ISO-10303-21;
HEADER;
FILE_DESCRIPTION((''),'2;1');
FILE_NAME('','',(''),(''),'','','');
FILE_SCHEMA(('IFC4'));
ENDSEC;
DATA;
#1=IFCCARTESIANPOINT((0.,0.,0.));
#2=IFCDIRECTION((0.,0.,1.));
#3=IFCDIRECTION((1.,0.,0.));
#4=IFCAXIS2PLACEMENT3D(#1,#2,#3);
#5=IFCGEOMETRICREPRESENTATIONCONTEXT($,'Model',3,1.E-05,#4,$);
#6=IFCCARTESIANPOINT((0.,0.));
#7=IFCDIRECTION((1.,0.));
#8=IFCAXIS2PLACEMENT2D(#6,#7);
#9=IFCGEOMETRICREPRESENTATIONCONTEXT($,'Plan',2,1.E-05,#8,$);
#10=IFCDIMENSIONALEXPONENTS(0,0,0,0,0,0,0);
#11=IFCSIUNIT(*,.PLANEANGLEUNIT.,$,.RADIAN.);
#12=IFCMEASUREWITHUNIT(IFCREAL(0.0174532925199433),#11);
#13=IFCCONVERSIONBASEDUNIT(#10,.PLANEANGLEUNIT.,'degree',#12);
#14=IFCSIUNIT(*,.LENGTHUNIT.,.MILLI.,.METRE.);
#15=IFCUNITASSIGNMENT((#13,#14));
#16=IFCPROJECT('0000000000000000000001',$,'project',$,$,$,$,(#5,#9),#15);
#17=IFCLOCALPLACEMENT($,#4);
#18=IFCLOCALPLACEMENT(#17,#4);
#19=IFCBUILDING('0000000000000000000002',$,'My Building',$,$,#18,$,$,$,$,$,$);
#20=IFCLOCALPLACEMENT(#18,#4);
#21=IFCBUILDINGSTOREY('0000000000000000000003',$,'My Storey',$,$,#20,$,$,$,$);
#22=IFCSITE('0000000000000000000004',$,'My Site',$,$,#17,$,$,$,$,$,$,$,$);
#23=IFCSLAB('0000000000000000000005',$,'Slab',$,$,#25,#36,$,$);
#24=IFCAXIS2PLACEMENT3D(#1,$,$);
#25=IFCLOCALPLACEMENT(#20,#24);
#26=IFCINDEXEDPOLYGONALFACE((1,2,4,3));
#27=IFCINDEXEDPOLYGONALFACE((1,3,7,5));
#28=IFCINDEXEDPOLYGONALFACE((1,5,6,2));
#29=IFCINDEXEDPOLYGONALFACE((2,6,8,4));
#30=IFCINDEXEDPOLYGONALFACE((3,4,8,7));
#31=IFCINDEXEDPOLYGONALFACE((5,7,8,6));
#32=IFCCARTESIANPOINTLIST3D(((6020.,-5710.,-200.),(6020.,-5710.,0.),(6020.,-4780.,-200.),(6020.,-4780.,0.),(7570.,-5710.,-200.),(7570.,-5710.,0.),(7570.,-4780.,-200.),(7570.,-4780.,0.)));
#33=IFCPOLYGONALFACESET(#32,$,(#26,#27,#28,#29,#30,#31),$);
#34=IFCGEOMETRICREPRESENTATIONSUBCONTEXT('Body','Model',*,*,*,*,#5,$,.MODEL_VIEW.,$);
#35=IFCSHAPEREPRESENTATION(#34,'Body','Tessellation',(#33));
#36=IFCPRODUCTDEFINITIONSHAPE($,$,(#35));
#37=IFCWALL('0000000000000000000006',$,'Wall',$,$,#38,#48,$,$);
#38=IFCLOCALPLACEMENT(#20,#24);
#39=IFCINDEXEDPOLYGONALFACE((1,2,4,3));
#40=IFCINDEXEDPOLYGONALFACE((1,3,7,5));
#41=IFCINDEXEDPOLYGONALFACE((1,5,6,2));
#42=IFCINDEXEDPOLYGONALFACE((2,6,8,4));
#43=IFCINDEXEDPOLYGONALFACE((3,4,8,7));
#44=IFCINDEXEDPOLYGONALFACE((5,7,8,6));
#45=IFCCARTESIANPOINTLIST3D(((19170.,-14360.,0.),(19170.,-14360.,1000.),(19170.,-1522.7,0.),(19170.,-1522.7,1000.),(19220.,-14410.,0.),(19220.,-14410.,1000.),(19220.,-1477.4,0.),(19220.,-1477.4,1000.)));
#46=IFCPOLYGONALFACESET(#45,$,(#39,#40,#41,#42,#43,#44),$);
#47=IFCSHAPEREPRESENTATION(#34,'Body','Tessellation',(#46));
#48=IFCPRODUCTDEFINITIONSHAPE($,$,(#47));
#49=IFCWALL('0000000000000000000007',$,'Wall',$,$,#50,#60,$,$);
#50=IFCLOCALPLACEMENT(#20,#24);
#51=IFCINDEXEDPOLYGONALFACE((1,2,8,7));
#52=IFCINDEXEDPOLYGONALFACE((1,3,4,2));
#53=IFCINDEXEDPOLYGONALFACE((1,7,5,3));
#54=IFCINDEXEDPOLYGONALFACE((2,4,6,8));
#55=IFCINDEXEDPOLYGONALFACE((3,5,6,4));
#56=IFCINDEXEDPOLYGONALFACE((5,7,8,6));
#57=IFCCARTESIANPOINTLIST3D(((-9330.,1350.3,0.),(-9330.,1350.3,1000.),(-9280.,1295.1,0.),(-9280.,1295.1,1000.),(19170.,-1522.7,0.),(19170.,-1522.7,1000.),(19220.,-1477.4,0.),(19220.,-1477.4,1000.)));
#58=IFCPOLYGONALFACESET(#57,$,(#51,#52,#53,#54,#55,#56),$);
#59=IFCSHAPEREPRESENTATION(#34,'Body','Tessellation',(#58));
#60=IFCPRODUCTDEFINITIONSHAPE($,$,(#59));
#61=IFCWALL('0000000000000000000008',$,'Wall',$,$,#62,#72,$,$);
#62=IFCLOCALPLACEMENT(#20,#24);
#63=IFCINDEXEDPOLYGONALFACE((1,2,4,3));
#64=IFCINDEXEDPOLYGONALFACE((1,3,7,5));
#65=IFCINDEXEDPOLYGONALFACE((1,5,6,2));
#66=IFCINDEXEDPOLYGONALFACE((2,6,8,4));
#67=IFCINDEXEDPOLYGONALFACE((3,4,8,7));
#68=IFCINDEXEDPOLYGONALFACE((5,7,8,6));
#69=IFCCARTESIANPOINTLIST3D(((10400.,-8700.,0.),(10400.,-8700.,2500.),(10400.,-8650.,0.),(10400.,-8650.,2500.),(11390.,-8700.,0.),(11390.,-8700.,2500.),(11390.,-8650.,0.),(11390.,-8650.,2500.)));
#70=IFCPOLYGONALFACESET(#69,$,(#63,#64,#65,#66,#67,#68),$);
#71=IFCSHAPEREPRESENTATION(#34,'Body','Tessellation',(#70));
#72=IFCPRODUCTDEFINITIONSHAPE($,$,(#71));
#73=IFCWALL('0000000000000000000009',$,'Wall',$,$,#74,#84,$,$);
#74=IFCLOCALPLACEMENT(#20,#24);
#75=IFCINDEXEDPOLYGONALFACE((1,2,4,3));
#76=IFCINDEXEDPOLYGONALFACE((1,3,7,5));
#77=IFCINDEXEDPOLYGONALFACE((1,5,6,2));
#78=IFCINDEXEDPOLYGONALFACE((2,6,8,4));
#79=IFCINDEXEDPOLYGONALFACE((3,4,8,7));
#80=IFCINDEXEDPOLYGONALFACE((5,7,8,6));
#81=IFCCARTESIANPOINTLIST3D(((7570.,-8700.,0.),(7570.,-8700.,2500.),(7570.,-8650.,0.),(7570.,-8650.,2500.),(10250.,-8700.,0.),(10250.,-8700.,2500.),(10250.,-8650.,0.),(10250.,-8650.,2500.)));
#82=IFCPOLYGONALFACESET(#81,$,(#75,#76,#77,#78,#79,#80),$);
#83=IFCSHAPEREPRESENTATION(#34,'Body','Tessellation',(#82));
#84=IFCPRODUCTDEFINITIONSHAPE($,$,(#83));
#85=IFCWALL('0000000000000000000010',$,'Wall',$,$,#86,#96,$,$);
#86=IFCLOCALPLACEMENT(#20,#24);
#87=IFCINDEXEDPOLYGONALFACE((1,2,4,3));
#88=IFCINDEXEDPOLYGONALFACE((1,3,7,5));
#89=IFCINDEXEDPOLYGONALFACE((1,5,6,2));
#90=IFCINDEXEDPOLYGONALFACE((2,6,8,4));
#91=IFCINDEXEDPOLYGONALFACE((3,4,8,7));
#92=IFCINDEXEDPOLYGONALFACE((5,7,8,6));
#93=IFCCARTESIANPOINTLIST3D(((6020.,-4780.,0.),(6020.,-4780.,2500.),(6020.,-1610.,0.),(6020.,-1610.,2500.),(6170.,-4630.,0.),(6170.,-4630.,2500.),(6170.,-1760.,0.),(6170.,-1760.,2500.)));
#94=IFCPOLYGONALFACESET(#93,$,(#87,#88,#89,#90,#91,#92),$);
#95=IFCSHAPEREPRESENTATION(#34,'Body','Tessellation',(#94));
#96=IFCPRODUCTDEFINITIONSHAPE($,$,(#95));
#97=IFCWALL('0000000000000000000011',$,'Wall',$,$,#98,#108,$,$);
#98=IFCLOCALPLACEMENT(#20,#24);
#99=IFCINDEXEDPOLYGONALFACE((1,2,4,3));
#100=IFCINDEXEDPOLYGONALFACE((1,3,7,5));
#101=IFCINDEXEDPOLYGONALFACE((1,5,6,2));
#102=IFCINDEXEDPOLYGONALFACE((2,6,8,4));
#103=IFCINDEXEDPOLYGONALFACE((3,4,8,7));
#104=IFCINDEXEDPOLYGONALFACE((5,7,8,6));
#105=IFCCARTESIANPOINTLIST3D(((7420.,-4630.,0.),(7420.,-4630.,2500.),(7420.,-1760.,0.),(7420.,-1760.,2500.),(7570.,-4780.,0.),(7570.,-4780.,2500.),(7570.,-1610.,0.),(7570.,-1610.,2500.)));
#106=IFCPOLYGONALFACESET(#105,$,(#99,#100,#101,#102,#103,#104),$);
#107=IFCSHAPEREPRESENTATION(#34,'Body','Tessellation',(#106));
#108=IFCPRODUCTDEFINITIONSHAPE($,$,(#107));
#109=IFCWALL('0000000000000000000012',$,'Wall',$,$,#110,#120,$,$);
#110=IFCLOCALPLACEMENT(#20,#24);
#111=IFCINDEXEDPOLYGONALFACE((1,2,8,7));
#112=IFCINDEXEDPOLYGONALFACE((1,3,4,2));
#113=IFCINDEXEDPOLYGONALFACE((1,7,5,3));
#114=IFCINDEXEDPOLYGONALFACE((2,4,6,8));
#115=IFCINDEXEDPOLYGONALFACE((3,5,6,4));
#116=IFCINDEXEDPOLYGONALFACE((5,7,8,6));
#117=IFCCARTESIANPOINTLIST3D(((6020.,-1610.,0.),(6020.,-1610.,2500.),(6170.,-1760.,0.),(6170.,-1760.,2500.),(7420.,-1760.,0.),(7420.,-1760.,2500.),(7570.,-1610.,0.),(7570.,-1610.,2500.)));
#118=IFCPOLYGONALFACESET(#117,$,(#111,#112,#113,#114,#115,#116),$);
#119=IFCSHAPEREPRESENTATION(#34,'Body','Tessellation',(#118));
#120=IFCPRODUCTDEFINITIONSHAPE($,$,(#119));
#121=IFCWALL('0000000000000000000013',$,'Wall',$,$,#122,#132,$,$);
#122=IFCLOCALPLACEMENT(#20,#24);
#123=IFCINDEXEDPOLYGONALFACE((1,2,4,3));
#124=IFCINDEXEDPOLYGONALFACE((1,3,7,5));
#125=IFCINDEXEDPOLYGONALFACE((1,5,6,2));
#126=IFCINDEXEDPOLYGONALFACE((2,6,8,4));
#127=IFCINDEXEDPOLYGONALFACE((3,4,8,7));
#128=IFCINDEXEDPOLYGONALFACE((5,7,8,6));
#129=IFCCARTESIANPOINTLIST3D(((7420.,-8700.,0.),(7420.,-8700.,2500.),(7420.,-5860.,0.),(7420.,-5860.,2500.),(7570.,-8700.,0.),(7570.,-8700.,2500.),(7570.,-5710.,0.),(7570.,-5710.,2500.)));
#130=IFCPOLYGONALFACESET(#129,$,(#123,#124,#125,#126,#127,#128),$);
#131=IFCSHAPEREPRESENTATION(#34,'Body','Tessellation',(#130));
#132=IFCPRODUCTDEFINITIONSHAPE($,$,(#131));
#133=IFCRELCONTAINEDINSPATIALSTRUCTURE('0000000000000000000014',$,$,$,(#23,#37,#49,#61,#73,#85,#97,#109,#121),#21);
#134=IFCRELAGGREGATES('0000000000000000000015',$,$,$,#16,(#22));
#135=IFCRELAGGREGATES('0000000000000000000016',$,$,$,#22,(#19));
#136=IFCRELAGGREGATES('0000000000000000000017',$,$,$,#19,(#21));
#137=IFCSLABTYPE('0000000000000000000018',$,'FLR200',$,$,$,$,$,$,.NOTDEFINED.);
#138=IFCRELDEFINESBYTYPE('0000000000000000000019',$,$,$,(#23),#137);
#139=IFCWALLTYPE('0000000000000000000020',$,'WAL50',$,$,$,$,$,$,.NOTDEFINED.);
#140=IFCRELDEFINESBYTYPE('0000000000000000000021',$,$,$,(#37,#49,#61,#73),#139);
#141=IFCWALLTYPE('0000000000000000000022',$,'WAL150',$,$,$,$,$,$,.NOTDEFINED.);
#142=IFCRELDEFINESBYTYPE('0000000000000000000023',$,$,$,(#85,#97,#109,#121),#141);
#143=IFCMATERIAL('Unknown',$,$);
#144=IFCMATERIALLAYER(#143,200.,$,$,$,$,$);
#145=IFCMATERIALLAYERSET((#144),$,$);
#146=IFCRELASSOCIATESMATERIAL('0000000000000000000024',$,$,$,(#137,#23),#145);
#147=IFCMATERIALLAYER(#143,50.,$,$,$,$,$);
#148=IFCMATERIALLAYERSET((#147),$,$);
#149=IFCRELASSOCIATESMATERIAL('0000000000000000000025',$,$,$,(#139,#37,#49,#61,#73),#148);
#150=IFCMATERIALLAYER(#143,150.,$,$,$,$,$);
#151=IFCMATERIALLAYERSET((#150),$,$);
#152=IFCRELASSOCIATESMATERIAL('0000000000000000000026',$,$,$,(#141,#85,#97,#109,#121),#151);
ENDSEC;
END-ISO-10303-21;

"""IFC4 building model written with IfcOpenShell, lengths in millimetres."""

from ifc_helpers import new_model, entity, si_unit, converted_unit, frame, origin_with_axes, origin_2d_with_axis, place, context, subcontext, project, spatial, line, indexed_curve, outline, extrude, material, layer, layer_set, layer_usage, type_object, element, save


model = new_model("IFC4")

# Units and contexts
model_context = context("Model", 3, precision=1e-05, world=origin_with_axes())
plan_context = context("Plan", 2, precision=1e-05, world=origin_2d_with_axis())
body_context_1 = subcontext(model_context, "Body", "Model", "MODEL_VIEW")
ifc_project = project(units=[converted_unit("PLANEANGLEUNIT", "degree", entity("IfcReal", 0.0174532925199433), si_unit("PLANEANGLEUNIT", "RADIAN"), dimensions=[0, 0, 0, 0, 0, 0, 0]), si_unit("LENGTHUNIT", "METRE", prefix="MILLI")], contexts=[model_context, plan_context])

# Site, building, storey
site_placement = place(None, origin_with_axes())
site = spatial("IfcSite", under=ifc_project, at=site_placement, Name="My Site")
building_placement = place(site_placement, origin_with_axes())
building = spatial("IfcBuilding", under=site, at=building_placement, Name="My Building")
storey_placement = place(building_placement, origin_with_axes())
storey = spatial("IfcBuildingStorey", under=building, at=storey_placement, Name="My Storey")

# Shared definitions
ifc_material = material(Name="Unknown")

# Slab
ifc_layer_1 = layer(ifc_material, 200.0)
ifc_layer_set_1 = layer_set([ifc_layer_1])
slab_type = type_object("IfcSlabType", Name="FLR200", PredefinedType="NOTDEFINED", material=ifc_layer_set_1)
ifc_layer_usage_1 = layer_usage(ifc_layer_set_1, "AXIS3", "POSITIVE", -200.0)
slab_1_placement = place(storey_placement, frame((7570.0, -4780.0, 0.0), z_axis=(0.0, 0.0, 1.0), x_axis=(1.0, 0.0, 0.0)))
element("IfcSlab", 1, at=slab_1_placement, inside=storey, type_object=slab_type, material=ifc_layer_usage_1, Name="Slab", context=body_context_1, shape_type="SweptSolid", body=[
    extrude(outline(indexed_curve([(0.0, 0.0), (0.0, -930.0), (-1550.0, -930.0), (-1550.0, 0.0), (0.0, 0.0)])), frame((0.0, 0.0, -200.0), z_axis=(0.0, 0.0, 1.0), x_axis=(1.0, 0.0, 0.0)), (0.0, 0.0, 1.0), 200.0),
])

# Walls
ifc_layer_2 = layer(ifc_material, 50.0)
ifc_layer_set_2 = layer_set([ifc_layer_2])
ifc_layer_usage_2 = layer_usage(ifc_layer_set_2, "AXIS2", "POSITIVE", 0.0)
wall_type_1 = type_object("IfcWallType", Name="WAL50", PredefinedType="NOTDEFINED", material=ifc_layer_set_2)
wall_1_placement = place(storey_placement, frame((19220.0, -14410.0, 0.0), z_axis=(0.0, 0.0, 1.0), x_axis=(0.0, 1.0, 0.0)))
element("IfcWall", 2, at=wall_1_placement, inside=storey, type_object=wall_type_1, material=ifc_layer_usage_2, Name="Wall", context=body_context_1, shape_type="SweptSolid", body=[
    extrude(outline(indexed_curve([(0.0, 0.0), (50.0, 50.0), (12887.3, 50.0), (12932.6, 0.0)], segments=[line(1, 2, 3, 4, 1)])), origin_with_axes(), (0.0, 0.0, 1.0), 1000.0),
])
ifc_layer_usage_3 = layer_usage(ifc_layer_set_2, "AXIS2", "POSITIVE", 0.0)
wall_2_placement = place(storey_placement, frame((19220.0, -1477.4, 0.0), z_axis=(0.0, 0.0, 1.0), x_axis=(-0.995131, 0.098562, 0.0)))
element("IfcWall", 3, at=wall_2_placement, inside=storey, type_object=wall_type_1, material=ifc_layer_usage_3, Name="Wall", context=body_context_1, shape_type="SweptSolid", body=[
    extrude(outline(indexed_curve([(0.0, 0.0), (45.3, 50.0), (28634.5, 50.0), (28689.7, 0.0)], segments=[line(1, 2, 3, 4, 1)])), origin_with_axes(), (0.0, 0.0, 1.0), 1000.0),
])
ifc_layer_usage_4 = layer_usage(ifc_layer_set_2, "AXIS2", "POSITIVE", 0.0)
wall_3_placement = place(storey_placement, frame((10400.0, -8700.0, 0.0), z_axis=(0.0, 0.0, 1.0), x_axis=(1.0, 0.0, 0.0)))
element("IfcWall", 4, at=wall_3_placement, inside=storey, type_object=wall_type_1, material=ifc_layer_usage_4, Name="Wall", context=body_context_1, shape_type="SweptSolid", body=[
    extrude(outline(indexed_curve([(0.0, 0.0), (0.0, 50.0), (990.0, 50.0), (990.0, 0.0)], segments=[line(1, 2, 3, 4, 1)])), origin_with_axes(), (0.0, 0.0, 1.0), 2500.0),
])
ifc_layer_usage_5 = layer_usage(ifc_layer_set_2, "AXIS2", "POSITIVE", 0.0)
wall_4_placement = place(storey_placement, frame((7570.0, -8700.0, 0.0), z_axis=(0.0, 0.0, 1.0), x_axis=(1.0, 0.0, 0.0)))
element("IfcWall", 5, at=wall_4_placement, inside=storey, type_object=wall_type_1, material=ifc_layer_usage_5, Name="Wall", context=body_context_1, shape_type="SweptSolid", body=[
    extrude(outline(indexed_curve([(0.0, 0.0), (0.0, 50.0), (2680.0, 50.0), (2680.0, 0.0)], segments=[line(1, 2, 3, 4, 1)])), origin_with_axes(), (0.0, 0.0, 1.0), 2500.0),
])
ifc_layer_3 = layer(ifc_material, 150.0)
ifc_layer_set_3 = layer_set([ifc_layer_3])
ifc_layer_usage_6 = layer_usage(ifc_layer_set_3, "AXIS2", "POSITIVE", 0.0)
wall_type_2 = type_object("IfcWallType", Name="WAL150", PredefinedType="NOTDEFINED", material=ifc_layer_set_3)
wall_5_placement = place(storey_placement, frame((6020.0, -1610.0, 0.0), z_axis=(0.0, 0.0, 1.0), x_axis=(0.0, -1.0, 0.0)))
element("IfcWall", 6, at=wall_5_placement, inside=storey, type_object=wall_type_2, material=ifc_layer_usage_6, Name="Wall", context=body_context_1, shape_type="SweptSolid", body=[
    extrude(outline(indexed_curve([(0.0, 0.0), (150.0, 150.0), (3020.0, 150.0), (3170.0, 0.0)], segments=[line(1, 2, 3, 4, 1)])), origin_with_axes(), (0.0, 0.0, 1.0), 2500.0),
])
ifc_layer_usage_7 = layer_usage(ifc_layer_set_3, "AXIS2", "POSITIVE", 0.0)
wall_6_placement = place(storey_placement, frame((7570.0, -4780.0, 0.0), z_axis=(0.0, 0.0, 1.0), x_axis=(0.0, 1.0, 0.0)))
element("IfcWall", 7, at=wall_6_placement, inside=storey, type_object=wall_type_2, material=ifc_layer_usage_7, Name="Wall", context=body_context_1, shape_type="SweptSolid", body=[
    extrude(outline(indexed_curve([(0.0, 0.0), (150.0, 150.0), (3020.0, 150.0), (3170.0, 0.0)], segments=[line(1, 2, 3, 4, 1)])), origin_with_axes(), (0.0, 0.0, 1.0), 2500.0),
])
ifc_layer_usage_8 = layer_usage(ifc_layer_set_3, "AXIS2", "POSITIVE", 0.0)
wall_7_placement = place(storey_placement, frame((7570.0, -1610.0, 0.0), z_axis=(0.0, 0.0, 1.0), x_axis=(-1.0, 0.0, 0.0)))
element("IfcWall", 8, at=wall_7_placement, inside=storey, type_object=wall_type_2, material=ifc_layer_usage_8, Name="Wall", context=body_context_1, shape_type="SweptSolid", body=[
    extrude(outline(indexed_curve([(0.0, 0.0), (150.0, 150.0), (1400.0, 150.0), (1550.0, 0.0)], segments=[line(1, 2, 3, 4, 1)])), origin_with_axes(), (0.0, 0.0, 1.0), 2500.0),
])
ifc_layer_usage_9 = layer_usage(ifc_layer_set_3, "AXIS2", "POSITIVE", 0.0)
wall_8_placement = place(storey_placement, frame((7570.0, -8700.0, 0.0), z_axis=(0.0, 0.0, 1.0), x_axis=(0.0, 1.0, 0.0)))
element("IfcWall", 9, at=wall_8_placement, inside=storey, type_object=wall_type_2, material=ifc_layer_usage_9, Name="Wall", context=body_context_1, shape_type="SweptSolid", body=[
    extrude(outline(indexed_curve([(0.0, 0.0), (0.0, 150.0), (2840.0, 150.0), (2990.0, 0.0)], segments=[line(1, 2, 3, 4, 1)])), origin_with_axes(), (0.0, 0.0, 1.0), 2500.0),
])

save(model, "model.ifc")
